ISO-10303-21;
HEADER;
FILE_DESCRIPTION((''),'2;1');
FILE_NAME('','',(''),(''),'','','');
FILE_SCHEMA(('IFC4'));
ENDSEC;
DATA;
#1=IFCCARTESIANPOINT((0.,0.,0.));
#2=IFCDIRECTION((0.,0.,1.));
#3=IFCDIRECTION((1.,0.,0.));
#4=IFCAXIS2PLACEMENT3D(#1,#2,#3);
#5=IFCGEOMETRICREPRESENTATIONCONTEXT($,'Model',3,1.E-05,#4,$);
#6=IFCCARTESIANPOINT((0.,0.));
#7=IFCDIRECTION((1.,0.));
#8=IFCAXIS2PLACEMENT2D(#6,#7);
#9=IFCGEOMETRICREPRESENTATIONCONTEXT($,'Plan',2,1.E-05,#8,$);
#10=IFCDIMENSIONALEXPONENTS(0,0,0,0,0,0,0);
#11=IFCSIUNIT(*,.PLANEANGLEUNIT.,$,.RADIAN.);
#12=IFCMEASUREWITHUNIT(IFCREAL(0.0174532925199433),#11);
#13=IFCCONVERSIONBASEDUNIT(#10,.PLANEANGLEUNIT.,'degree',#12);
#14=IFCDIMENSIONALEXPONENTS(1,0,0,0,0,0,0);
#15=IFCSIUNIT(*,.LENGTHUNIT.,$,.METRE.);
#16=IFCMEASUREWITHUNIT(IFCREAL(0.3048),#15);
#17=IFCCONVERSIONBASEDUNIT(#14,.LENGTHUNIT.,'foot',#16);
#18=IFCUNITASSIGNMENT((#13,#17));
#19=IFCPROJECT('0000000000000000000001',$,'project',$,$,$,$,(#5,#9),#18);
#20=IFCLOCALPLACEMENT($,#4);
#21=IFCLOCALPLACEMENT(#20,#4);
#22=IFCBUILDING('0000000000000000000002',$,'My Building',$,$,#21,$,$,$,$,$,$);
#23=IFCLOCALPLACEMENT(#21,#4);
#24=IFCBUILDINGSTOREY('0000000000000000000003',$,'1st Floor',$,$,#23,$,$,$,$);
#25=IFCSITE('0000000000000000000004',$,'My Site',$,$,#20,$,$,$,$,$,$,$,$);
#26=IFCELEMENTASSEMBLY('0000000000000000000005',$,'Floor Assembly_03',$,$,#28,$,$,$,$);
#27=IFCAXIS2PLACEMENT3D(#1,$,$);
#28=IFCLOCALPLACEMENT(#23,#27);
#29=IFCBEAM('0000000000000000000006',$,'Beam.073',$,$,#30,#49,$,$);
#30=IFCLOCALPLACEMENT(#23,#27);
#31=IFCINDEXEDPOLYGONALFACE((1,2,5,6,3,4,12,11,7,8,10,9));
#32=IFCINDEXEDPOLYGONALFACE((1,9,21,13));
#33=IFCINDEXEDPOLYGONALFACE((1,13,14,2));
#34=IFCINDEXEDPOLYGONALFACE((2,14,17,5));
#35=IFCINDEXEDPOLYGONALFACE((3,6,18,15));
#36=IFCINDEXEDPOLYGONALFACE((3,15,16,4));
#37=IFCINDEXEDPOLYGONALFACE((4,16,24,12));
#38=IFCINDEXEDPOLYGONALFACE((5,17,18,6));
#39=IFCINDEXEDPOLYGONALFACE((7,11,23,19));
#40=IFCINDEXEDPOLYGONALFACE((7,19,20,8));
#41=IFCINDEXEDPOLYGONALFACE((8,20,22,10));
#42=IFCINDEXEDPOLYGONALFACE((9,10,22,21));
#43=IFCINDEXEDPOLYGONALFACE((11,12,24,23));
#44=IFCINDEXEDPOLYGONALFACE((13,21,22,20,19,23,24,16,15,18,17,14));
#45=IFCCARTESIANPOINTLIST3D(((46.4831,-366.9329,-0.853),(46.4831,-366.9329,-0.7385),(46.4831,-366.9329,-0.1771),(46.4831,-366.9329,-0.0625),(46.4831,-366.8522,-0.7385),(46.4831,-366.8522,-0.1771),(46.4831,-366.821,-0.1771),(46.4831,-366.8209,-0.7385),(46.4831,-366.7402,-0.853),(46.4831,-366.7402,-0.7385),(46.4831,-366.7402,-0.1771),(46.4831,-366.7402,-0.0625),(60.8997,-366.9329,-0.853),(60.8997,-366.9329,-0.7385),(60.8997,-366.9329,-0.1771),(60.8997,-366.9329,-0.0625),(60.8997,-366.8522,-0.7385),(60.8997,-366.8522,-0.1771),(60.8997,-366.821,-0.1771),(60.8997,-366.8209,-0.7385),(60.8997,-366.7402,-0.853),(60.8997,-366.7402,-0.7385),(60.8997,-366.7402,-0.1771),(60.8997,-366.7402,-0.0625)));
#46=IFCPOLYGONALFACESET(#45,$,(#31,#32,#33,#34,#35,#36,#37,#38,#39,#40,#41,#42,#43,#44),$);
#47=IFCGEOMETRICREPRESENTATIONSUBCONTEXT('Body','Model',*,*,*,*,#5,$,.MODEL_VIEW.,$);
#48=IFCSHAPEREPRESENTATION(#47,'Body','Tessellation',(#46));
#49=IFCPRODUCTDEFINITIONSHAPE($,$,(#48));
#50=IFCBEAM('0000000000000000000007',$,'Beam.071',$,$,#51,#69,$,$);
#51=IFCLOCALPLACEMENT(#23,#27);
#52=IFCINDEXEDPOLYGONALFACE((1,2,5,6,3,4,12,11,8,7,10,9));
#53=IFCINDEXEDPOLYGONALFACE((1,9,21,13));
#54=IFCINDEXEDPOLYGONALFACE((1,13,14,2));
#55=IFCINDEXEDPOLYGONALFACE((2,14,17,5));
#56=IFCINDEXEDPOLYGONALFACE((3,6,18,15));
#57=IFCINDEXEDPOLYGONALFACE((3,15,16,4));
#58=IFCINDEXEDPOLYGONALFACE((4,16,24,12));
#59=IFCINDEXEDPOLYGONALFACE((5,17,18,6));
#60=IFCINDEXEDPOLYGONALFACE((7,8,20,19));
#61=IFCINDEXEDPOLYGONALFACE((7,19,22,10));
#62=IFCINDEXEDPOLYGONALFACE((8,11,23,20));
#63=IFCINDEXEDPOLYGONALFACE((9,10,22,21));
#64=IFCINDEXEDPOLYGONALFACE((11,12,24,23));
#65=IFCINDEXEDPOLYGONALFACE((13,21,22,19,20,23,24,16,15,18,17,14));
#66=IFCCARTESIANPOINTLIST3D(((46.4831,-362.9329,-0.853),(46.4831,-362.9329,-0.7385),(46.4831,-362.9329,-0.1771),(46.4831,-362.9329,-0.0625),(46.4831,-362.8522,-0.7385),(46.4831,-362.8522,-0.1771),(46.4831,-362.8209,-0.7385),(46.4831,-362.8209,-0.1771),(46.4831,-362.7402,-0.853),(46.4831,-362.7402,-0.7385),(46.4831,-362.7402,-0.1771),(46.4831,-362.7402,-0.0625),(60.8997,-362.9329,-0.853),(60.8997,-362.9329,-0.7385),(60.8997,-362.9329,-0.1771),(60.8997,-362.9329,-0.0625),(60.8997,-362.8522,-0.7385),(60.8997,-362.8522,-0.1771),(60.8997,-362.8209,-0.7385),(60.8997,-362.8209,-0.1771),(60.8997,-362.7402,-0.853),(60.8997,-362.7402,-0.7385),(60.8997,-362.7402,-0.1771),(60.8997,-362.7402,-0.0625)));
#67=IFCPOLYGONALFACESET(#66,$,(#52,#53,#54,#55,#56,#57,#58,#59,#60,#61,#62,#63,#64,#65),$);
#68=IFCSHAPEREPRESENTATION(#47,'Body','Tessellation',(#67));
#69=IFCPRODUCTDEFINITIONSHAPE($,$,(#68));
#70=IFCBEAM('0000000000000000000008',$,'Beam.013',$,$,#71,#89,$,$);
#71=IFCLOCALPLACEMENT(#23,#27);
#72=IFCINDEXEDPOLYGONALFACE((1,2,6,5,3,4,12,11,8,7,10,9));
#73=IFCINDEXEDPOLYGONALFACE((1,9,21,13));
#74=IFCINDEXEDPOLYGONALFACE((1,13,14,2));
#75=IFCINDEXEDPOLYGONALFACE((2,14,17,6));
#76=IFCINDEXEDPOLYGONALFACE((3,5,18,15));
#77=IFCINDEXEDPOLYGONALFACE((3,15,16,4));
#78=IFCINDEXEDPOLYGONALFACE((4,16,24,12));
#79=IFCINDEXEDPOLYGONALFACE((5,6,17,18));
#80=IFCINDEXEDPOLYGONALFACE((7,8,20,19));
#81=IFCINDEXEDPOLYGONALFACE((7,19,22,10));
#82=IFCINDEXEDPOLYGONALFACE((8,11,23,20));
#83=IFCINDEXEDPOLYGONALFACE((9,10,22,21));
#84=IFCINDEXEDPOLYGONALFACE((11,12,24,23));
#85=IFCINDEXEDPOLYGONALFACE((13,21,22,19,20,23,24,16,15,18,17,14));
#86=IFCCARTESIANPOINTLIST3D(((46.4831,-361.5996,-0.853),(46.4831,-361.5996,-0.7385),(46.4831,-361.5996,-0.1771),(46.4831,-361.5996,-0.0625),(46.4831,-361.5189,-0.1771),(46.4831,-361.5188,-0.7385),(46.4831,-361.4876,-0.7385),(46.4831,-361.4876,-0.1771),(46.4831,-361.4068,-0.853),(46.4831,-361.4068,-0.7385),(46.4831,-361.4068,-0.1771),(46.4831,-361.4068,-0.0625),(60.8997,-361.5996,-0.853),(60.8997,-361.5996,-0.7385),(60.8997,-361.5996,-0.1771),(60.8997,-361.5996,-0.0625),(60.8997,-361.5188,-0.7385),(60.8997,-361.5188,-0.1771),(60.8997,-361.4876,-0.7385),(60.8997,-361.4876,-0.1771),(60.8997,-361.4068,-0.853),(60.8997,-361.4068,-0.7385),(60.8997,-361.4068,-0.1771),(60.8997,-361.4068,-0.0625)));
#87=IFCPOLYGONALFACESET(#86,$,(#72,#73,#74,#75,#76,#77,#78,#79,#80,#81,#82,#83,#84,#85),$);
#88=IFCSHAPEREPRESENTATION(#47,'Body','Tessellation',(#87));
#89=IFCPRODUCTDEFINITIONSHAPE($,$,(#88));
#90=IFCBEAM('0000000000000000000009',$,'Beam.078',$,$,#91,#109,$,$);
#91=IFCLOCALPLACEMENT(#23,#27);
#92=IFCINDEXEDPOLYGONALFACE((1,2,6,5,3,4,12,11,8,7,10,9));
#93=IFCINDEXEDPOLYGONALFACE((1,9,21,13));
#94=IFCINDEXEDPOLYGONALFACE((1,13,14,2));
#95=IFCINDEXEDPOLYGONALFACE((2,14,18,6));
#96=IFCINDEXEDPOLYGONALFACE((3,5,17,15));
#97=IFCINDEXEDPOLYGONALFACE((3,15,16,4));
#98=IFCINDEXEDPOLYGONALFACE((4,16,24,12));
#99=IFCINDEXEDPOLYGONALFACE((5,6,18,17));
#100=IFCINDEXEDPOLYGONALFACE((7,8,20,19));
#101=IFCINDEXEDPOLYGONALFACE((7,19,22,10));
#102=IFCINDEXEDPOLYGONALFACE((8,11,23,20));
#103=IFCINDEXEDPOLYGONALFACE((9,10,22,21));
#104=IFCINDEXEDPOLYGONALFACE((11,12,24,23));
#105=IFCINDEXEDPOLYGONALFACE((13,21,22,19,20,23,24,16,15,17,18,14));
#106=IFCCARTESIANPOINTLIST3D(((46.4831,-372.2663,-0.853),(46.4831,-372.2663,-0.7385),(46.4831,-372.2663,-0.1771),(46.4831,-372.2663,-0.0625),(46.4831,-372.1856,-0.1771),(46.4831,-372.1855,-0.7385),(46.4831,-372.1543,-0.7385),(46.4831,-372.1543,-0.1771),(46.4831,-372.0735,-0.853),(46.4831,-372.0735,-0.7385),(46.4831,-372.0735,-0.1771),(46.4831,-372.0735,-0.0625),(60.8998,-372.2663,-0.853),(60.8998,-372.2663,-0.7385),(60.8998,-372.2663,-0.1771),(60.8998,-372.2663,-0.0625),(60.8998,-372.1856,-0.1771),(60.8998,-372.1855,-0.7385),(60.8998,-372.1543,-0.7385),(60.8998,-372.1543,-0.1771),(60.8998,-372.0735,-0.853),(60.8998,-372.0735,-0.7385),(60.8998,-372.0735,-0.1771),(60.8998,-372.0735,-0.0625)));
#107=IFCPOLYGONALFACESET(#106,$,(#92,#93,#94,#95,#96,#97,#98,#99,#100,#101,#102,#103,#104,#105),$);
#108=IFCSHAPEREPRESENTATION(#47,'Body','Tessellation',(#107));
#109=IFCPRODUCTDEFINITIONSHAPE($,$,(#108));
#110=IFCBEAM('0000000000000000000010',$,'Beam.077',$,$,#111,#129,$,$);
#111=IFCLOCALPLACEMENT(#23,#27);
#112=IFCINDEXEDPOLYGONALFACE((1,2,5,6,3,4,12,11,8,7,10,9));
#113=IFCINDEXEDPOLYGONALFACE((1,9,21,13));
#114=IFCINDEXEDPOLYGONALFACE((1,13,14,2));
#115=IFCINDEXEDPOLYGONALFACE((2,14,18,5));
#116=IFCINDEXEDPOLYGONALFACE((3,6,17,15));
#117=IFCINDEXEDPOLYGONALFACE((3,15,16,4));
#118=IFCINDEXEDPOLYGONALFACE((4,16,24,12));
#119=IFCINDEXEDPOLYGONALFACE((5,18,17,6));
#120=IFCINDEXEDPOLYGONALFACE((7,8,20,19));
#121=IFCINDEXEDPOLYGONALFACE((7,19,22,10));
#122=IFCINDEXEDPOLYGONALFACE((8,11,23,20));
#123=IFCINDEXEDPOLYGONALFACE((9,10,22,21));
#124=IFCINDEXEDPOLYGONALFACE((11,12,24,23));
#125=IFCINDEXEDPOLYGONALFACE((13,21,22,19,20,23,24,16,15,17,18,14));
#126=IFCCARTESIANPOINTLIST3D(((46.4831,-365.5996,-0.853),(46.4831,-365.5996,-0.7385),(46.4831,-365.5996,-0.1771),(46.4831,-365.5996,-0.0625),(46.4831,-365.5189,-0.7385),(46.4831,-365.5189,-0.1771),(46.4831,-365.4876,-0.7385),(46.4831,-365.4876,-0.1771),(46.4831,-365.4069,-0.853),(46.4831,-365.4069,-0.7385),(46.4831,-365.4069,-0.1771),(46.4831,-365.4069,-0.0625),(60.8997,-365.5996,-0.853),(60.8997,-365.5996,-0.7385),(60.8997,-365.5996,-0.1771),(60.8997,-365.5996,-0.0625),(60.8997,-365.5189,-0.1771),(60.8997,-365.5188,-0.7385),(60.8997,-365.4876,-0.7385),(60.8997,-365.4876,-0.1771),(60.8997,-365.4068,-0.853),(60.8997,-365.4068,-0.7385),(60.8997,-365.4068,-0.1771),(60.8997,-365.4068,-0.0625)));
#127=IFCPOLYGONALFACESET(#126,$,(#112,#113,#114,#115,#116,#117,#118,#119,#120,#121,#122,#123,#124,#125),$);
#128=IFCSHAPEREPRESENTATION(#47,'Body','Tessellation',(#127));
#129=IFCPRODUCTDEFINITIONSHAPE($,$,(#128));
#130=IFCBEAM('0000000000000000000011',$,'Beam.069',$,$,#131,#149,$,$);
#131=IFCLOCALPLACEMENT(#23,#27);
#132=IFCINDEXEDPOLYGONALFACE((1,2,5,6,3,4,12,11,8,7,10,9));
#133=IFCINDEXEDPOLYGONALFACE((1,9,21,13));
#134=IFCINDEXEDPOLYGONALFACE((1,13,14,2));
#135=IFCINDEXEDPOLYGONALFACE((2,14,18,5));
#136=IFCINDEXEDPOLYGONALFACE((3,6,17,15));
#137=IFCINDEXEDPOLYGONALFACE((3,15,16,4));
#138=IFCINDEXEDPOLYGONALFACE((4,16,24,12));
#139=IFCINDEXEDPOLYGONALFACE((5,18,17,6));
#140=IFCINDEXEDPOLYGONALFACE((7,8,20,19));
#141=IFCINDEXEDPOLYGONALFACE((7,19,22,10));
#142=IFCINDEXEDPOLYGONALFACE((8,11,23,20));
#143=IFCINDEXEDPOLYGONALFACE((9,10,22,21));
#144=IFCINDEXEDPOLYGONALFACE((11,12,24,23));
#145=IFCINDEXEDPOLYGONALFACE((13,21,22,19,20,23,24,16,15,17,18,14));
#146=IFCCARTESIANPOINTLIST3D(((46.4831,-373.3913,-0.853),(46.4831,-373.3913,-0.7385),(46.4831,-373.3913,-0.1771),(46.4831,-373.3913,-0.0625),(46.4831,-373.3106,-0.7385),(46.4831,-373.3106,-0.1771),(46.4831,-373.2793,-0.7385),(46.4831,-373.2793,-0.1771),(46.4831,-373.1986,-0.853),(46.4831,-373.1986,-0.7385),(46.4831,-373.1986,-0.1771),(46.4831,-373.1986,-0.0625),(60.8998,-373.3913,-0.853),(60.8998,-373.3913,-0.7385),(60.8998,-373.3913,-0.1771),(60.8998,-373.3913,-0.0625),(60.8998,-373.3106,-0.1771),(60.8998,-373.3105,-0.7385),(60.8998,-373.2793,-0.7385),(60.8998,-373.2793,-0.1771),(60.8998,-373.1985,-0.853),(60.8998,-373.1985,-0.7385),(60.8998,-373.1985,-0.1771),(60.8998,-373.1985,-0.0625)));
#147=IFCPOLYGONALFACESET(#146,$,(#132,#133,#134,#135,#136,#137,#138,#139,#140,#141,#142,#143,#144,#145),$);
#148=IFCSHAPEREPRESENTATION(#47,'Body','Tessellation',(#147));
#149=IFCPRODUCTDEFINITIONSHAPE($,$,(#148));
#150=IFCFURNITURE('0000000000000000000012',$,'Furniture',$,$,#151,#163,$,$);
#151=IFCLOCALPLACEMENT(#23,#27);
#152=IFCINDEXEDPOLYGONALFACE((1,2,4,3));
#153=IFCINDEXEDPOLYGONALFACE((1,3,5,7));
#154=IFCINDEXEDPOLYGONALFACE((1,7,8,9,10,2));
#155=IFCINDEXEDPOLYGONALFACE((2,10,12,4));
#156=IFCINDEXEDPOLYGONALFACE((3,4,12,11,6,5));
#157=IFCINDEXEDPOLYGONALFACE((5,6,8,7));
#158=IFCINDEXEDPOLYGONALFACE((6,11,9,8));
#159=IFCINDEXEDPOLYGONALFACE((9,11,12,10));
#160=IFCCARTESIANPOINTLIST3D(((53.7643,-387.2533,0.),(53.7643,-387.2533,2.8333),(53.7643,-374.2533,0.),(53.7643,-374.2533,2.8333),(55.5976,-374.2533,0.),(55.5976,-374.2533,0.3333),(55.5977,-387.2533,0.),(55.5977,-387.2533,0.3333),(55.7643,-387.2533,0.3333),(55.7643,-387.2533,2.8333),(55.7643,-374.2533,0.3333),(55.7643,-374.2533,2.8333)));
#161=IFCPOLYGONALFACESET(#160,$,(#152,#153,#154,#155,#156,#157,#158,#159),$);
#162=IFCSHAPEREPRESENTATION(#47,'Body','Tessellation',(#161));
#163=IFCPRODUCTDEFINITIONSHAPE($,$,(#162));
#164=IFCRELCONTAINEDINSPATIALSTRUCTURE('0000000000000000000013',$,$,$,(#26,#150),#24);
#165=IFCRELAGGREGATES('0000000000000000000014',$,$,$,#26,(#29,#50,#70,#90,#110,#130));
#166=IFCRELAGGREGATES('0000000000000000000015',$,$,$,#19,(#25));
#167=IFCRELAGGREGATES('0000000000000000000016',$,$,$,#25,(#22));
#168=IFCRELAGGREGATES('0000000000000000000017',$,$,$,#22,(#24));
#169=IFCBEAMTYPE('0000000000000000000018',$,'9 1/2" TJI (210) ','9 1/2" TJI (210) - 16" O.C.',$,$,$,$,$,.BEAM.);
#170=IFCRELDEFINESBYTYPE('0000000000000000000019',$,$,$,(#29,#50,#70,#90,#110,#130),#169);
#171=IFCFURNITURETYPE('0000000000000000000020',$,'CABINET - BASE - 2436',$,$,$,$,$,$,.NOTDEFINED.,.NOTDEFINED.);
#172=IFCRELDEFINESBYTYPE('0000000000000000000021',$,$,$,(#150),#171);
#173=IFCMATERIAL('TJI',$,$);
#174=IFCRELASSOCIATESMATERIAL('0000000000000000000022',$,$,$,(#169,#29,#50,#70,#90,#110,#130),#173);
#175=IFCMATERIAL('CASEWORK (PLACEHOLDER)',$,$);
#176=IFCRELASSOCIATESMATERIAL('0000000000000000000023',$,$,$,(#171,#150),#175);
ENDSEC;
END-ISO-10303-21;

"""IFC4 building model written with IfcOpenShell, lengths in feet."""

from ifc_helpers import new_model, entity, si_unit, converted_unit, frame, origin_with_axes, origin_2d_with_axis, place, context, subcontext, project, spatial, indexed_curve, outline, extrude, material, material_profile, profile_set, profile_usage, type_object, element, aggregate, save


model = new_model("IFC4")

# Units and contexts
model_context = context("Model", 3, precision=1e-05, world=origin_with_axes())
plan_context = context("Plan", 2, precision=1e-05, world=origin_2d_with_axis())
body_context = subcontext(model_context, "Body", "Model", "MODEL_VIEW")
ifc_project = project(units=[converted_unit("PLANEANGLEUNIT", "degree", entity("IfcReal", 0.0174532925199433), si_unit("PLANEANGLEUNIT", "RADIAN"), dimensions=[0, 0, 0, 0, 0, 0, 0]), converted_unit("LENGTHUNIT", "foot", entity("IfcReal", 0.3048), si_unit("LENGTHUNIT", "METRE"), dimensions=[1, 0, 0, 0, 0, 0, 0])], contexts=[model_context, plan_context])

# Site, building, storey
site_placement = place(None, origin_with_axes())
site = spatial("IfcSite", under=ifc_project, at=site_placement, Name="My Site")
building_placement = place(site_placement, origin_with_axes())
building = spatial("IfcBuilding", under=site, at=building_placement, Name="My Building")
storey_placement = place(building_placement, origin_with_axes())
storey = spatial("IfcBuildingStorey", under=building, at=storey_placement, Name="1st Floor")

# Element assembly, beams
ifc_material_1 = material(Name="TJI")
ifc_material_profile_1 = material_profile(ifc_material_1, outline(indexed_curve([(0.0964, 0.7905), (-0.0964, 0.7905), (-0.0964, 0.6759), (-0.0156, 0.6759), (-0.0156, 0.1146), (-0.0964, 0.1146), (-0.0964, 0.0), (0.0964, 0.0), (0.0964, 0.1146), (0.0156, 0.1146), (0.0157, 0.6759), (0.0964, 0.6759), (0.0964, 0.7905)])))
ifc_profile_set_1 = profile_set([ifc_material_profile_1])
beam_type_1 = type_object("IfcBeamType", Name="9 1/2\" TJI (210) ", Description="9 1/2\" TJI (210) - 16\" O.C.", PredefinedType="BEAM", material=ifc_profile_set_1)
assembly_1_placement = place(storey_placement, frame((60.8998, -373.5996, -0.0625), z_axis=(0.0, 0.0, 1.0), x_axis=(-1.0, -0.000001, 0.0)))
assembly_1 = element("IfcElementAssembly", 1, at=assembly_1_placement, inside=storey, Name="Floor Assembly_03")
ifc_profile_usage_1 = profile_usage(ifc_profile_set_1, cardinal=5)
beam_1_placement = place(assembly_1_placement, frame((0.0, -6.763, -0.7905), z_axis=(1.0, 0.0, 0.0), x_axis=(0.0, 1.0, 0.0)))
beam_1 = element("IfcBeam", 2, at=beam_1_placement, type_object=beam_type_1, material=ifc_profile_usage_1, Name="Beam.073", context=body_context, shape_type="SweptSolid", body=[
    extrude(outline(indexed_curve([(0.0964, 0.7905), (-0.0964, 0.7905), (-0.0964, 0.6759), (-0.0156, 0.6759), (-0.0156, 0.1146), (-0.0964, 0.1146), (-0.0964, 0.0), (0.0964, 0.0), (0.0964, 0.1146), (0.0156, 0.1146), (0.0157, 0.6759), (0.0964, 0.6759), (0.0964, 0.7905)])), origin_with_axes(), (0.0, 0.0, 1.0), 14.4167),
])
ifc_profile_usage_2 = profile_usage(ifc_profile_set_1, cardinal=5)
beam_2_placement = place(assembly_1_placement, frame((0.0, -10.7631, -0.7905), z_axis=(1.0, 0.0, 0.0), x_axis=(0.0, 1.0, 0.0)))
beam_2 = element("IfcBeam", 3, at=beam_2_placement, type_object=beam_type_1, material=ifc_profile_usage_2, Name="Beam.071", context=body_context, shape_type="SweptSolid", body=[
    extrude(outline(indexed_curve([(0.0964, 0.7905), (-0.0964, 0.7905), (-0.0964, 0.6759), (-0.0156, 0.6759), (-0.0156, 0.1146), (-0.0964, 0.1146), (-0.0964, 0.0), (0.0964, 0.0), (0.0964, 0.1146), (0.0156, 0.1146), (0.0157, 0.6759), (0.0964, 0.6759), (0.0964, 0.7905)])), origin_with_axes(), (0.0, 0.0, 1.0), 14.4167),
])
ifc_profile_usage_3 = profile_usage(ifc_profile_set_1, cardinal=5)
beam_3_placement = place(assembly_1_placement, frame((0.0, -12.0964, -0.7905), z_axis=(1.0, 0.0, 0.0), x_axis=(0.0, 1.0, 0.0)))
beam_3 = element("IfcBeam", 4, at=beam_3_placement, type_object=beam_type_1, material=ifc_profile_usage_3, Name="Beam.013", context=body_context, shape_type="SweptSolid", body=[
    extrude(outline(indexed_curve([(0.0964, 0.7905), (-0.0964, 0.7905), (-0.0964, 0.6759), (-0.0156, 0.6759), (-0.0156, 0.1146), (-0.0964, 0.1146), (-0.0964, 0.0), (0.0964, 0.0), (0.0964, 0.1146), (0.0156, 0.1146), (0.0157, 0.6759), (0.0964, 0.6759), (0.0964, 0.7905)])), origin_with_axes(), (0.0, 0.0, 1.0), 14.4167),
])
ifc_profile_usage_4 = profile_usage(ifc_profile_set_1, cardinal=5)
beam_4_placement = place(assembly_1_placement, frame((0.0, -1.4297, -0.7905), z_axis=(1.0, 0.0, 0.0), x_axis=(0.0, 1.0, 0.0)))
beam_4 = element("IfcBeam", 5, at=beam_4_placement, type_object=beam_type_1, material=ifc_profile_usage_4, Name="Beam.078", context=body_context, shape_type="SweptSolid", body=[
    extrude(outline(indexed_curve([(0.0964, 0.7905), (-0.0964, 0.7905), (-0.0964, 0.6759), (-0.0156, 0.6759), (-0.0156, 0.1146), (-0.0964, 0.1146), (-0.0964, 0.0), (0.0964, 0.0), (0.0964, 0.1146), (0.0156, 0.1146), (0.0157, 0.6759), (0.0964, 0.6759), (0.0964, 0.7905)])), origin_with_axes(), (0.0, 0.0, 1.0), 14.4167),
])
ifc_profile_usage_5 = profile_usage(ifc_profile_set_1, cardinal=5)
beam_5_placement = place(assembly_1_placement, frame((0.0, -8.0964, -0.7905), z_axis=(1.0, 0.0, 0.0), x_axis=(0.0, 1.0, 0.0)))
beam_5 = element("IfcBeam", 6, at=beam_5_placement, type_object=beam_type_1, material=ifc_profile_usage_5, Name="Beam.077", context=body_context, shape_type="SweptSolid", body=[
    extrude(outline(indexed_curve([(0.0964, 0.7905), (-0.0964, 0.7905), (-0.0964, 0.6759), (-0.0156, 0.6759), (-0.0156, 0.1146), (-0.0964, 0.1146), (-0.0964, 0.0), (0.0964, 0.0), (0.0964, 0.1146), (0.0156, 0.1146), (0.0157, 0.6759), (0.0964, 0.6759), (0.0964, 0.7905)])), origin_with_axes(), (0.0, 0.0, 1.0), 14.4167),
])
ifc_profile_usage_6 = profile_usage(ifc_profile_set_1, cardinal=5)
beam_6_placement = place(assembly_1_placement, frame((0.0, -0.3047, -0.7905), z_axis=(1.0, 0.0, 0.0), x_axis=(0.0, 1.0, 0.0)))
beam_6 = element("IfcBeam", 7, at=beam_6_placement, type_object=beam_type_1, material=ifc_profile_usage_6, Name="Beam.069", context=body_context, shape_type="SweptSolid", body=[
    extrude(outline(indexed_curve([(0.0964, 0.7905), (-0.0964, 0.7905), (-0.0964, 0.6759), (-0.0156, 0.6759), (-0.0156, 0.1146), (-0.0964, 0.1146), (-0.0964, 0.0), (0.0964, 0.0), (0.0964, 0.1146), (0.0156, 0.1146), (0.0157, 0.6759), (0.0964, 0.6759), (0.0964, 0.7905)])), origin_with_axes(), (0.0, 0.0, 1.0), 14.4167),
])
aggregate(assembly_1, [beam_1, beam_2, beam_3, beam_4, beam_5, beam_6])

# Furniture
ifc_material_2 = material(Name="CASEWORK (PLACEHOLDER)")
ifc_material_profile_2 = material_profile(ifc_material_2, outline(indexed_curve([(2.0, 0.3333), (2.0, 2.8333), (0.0, 2.8333), (0.0, 0.0), (1.8333, 0.0), (1.8333, 0.3333), (2.0, 0.3333)])))
ifc_profile_set_2 = profile_set([ifc_material_profile_2])
ifc_profile_usage_7 = profile_usage(ifc_profile_set_2, cardinal=5)
ifc_material_profile_3 = material_profile(ifc_material_2, outline(indexed_curve([(2.0, 0.3333), (2.0, 2.8333), (0.0, 2.8333), (0.0, 0.0), (1.8333, 0.0), (1.8333, 0.3333), (2.0, 0.3333)])))
ifc_profile_set_3 = profile_set([ifc_material_profile_3])
furniture_type_1 = type_object("IfcFurnitureType", Name="CABINET - BASE - 2436", AssemblyPlace="NOTDEFINED", PredefinedType="NOTDEFINED", material=ifc_profile_set_3)
furniture_1_placement = place(storey_placement, frame((53.7643, -374.2533, 0.0), z_axis=(0.000001, -1.0, 0.0), x_axis=(1.0, 0.000001, 0.0)))
element("IfcFurniture", 8, at=furniture_1_placement, inside=storey, type_object=furniture_type_1, material=ifc_profile_usage_7, Name="Furniture", context=body_context, shape_type="SweptSolid", body=[
    extrude(outline(indexed_curve([(2.0, 0.3333), (2.0, 2.8333), (0.0, 2.8333), (0.0, 0.0), (1.8333, 0.0), (1.8333, 0.3333), (2.0, 0.3333)])), origin_with_axes(), (0.0, 0.0, 1.0), 13.0),
])

save(model, "model.ifc")
